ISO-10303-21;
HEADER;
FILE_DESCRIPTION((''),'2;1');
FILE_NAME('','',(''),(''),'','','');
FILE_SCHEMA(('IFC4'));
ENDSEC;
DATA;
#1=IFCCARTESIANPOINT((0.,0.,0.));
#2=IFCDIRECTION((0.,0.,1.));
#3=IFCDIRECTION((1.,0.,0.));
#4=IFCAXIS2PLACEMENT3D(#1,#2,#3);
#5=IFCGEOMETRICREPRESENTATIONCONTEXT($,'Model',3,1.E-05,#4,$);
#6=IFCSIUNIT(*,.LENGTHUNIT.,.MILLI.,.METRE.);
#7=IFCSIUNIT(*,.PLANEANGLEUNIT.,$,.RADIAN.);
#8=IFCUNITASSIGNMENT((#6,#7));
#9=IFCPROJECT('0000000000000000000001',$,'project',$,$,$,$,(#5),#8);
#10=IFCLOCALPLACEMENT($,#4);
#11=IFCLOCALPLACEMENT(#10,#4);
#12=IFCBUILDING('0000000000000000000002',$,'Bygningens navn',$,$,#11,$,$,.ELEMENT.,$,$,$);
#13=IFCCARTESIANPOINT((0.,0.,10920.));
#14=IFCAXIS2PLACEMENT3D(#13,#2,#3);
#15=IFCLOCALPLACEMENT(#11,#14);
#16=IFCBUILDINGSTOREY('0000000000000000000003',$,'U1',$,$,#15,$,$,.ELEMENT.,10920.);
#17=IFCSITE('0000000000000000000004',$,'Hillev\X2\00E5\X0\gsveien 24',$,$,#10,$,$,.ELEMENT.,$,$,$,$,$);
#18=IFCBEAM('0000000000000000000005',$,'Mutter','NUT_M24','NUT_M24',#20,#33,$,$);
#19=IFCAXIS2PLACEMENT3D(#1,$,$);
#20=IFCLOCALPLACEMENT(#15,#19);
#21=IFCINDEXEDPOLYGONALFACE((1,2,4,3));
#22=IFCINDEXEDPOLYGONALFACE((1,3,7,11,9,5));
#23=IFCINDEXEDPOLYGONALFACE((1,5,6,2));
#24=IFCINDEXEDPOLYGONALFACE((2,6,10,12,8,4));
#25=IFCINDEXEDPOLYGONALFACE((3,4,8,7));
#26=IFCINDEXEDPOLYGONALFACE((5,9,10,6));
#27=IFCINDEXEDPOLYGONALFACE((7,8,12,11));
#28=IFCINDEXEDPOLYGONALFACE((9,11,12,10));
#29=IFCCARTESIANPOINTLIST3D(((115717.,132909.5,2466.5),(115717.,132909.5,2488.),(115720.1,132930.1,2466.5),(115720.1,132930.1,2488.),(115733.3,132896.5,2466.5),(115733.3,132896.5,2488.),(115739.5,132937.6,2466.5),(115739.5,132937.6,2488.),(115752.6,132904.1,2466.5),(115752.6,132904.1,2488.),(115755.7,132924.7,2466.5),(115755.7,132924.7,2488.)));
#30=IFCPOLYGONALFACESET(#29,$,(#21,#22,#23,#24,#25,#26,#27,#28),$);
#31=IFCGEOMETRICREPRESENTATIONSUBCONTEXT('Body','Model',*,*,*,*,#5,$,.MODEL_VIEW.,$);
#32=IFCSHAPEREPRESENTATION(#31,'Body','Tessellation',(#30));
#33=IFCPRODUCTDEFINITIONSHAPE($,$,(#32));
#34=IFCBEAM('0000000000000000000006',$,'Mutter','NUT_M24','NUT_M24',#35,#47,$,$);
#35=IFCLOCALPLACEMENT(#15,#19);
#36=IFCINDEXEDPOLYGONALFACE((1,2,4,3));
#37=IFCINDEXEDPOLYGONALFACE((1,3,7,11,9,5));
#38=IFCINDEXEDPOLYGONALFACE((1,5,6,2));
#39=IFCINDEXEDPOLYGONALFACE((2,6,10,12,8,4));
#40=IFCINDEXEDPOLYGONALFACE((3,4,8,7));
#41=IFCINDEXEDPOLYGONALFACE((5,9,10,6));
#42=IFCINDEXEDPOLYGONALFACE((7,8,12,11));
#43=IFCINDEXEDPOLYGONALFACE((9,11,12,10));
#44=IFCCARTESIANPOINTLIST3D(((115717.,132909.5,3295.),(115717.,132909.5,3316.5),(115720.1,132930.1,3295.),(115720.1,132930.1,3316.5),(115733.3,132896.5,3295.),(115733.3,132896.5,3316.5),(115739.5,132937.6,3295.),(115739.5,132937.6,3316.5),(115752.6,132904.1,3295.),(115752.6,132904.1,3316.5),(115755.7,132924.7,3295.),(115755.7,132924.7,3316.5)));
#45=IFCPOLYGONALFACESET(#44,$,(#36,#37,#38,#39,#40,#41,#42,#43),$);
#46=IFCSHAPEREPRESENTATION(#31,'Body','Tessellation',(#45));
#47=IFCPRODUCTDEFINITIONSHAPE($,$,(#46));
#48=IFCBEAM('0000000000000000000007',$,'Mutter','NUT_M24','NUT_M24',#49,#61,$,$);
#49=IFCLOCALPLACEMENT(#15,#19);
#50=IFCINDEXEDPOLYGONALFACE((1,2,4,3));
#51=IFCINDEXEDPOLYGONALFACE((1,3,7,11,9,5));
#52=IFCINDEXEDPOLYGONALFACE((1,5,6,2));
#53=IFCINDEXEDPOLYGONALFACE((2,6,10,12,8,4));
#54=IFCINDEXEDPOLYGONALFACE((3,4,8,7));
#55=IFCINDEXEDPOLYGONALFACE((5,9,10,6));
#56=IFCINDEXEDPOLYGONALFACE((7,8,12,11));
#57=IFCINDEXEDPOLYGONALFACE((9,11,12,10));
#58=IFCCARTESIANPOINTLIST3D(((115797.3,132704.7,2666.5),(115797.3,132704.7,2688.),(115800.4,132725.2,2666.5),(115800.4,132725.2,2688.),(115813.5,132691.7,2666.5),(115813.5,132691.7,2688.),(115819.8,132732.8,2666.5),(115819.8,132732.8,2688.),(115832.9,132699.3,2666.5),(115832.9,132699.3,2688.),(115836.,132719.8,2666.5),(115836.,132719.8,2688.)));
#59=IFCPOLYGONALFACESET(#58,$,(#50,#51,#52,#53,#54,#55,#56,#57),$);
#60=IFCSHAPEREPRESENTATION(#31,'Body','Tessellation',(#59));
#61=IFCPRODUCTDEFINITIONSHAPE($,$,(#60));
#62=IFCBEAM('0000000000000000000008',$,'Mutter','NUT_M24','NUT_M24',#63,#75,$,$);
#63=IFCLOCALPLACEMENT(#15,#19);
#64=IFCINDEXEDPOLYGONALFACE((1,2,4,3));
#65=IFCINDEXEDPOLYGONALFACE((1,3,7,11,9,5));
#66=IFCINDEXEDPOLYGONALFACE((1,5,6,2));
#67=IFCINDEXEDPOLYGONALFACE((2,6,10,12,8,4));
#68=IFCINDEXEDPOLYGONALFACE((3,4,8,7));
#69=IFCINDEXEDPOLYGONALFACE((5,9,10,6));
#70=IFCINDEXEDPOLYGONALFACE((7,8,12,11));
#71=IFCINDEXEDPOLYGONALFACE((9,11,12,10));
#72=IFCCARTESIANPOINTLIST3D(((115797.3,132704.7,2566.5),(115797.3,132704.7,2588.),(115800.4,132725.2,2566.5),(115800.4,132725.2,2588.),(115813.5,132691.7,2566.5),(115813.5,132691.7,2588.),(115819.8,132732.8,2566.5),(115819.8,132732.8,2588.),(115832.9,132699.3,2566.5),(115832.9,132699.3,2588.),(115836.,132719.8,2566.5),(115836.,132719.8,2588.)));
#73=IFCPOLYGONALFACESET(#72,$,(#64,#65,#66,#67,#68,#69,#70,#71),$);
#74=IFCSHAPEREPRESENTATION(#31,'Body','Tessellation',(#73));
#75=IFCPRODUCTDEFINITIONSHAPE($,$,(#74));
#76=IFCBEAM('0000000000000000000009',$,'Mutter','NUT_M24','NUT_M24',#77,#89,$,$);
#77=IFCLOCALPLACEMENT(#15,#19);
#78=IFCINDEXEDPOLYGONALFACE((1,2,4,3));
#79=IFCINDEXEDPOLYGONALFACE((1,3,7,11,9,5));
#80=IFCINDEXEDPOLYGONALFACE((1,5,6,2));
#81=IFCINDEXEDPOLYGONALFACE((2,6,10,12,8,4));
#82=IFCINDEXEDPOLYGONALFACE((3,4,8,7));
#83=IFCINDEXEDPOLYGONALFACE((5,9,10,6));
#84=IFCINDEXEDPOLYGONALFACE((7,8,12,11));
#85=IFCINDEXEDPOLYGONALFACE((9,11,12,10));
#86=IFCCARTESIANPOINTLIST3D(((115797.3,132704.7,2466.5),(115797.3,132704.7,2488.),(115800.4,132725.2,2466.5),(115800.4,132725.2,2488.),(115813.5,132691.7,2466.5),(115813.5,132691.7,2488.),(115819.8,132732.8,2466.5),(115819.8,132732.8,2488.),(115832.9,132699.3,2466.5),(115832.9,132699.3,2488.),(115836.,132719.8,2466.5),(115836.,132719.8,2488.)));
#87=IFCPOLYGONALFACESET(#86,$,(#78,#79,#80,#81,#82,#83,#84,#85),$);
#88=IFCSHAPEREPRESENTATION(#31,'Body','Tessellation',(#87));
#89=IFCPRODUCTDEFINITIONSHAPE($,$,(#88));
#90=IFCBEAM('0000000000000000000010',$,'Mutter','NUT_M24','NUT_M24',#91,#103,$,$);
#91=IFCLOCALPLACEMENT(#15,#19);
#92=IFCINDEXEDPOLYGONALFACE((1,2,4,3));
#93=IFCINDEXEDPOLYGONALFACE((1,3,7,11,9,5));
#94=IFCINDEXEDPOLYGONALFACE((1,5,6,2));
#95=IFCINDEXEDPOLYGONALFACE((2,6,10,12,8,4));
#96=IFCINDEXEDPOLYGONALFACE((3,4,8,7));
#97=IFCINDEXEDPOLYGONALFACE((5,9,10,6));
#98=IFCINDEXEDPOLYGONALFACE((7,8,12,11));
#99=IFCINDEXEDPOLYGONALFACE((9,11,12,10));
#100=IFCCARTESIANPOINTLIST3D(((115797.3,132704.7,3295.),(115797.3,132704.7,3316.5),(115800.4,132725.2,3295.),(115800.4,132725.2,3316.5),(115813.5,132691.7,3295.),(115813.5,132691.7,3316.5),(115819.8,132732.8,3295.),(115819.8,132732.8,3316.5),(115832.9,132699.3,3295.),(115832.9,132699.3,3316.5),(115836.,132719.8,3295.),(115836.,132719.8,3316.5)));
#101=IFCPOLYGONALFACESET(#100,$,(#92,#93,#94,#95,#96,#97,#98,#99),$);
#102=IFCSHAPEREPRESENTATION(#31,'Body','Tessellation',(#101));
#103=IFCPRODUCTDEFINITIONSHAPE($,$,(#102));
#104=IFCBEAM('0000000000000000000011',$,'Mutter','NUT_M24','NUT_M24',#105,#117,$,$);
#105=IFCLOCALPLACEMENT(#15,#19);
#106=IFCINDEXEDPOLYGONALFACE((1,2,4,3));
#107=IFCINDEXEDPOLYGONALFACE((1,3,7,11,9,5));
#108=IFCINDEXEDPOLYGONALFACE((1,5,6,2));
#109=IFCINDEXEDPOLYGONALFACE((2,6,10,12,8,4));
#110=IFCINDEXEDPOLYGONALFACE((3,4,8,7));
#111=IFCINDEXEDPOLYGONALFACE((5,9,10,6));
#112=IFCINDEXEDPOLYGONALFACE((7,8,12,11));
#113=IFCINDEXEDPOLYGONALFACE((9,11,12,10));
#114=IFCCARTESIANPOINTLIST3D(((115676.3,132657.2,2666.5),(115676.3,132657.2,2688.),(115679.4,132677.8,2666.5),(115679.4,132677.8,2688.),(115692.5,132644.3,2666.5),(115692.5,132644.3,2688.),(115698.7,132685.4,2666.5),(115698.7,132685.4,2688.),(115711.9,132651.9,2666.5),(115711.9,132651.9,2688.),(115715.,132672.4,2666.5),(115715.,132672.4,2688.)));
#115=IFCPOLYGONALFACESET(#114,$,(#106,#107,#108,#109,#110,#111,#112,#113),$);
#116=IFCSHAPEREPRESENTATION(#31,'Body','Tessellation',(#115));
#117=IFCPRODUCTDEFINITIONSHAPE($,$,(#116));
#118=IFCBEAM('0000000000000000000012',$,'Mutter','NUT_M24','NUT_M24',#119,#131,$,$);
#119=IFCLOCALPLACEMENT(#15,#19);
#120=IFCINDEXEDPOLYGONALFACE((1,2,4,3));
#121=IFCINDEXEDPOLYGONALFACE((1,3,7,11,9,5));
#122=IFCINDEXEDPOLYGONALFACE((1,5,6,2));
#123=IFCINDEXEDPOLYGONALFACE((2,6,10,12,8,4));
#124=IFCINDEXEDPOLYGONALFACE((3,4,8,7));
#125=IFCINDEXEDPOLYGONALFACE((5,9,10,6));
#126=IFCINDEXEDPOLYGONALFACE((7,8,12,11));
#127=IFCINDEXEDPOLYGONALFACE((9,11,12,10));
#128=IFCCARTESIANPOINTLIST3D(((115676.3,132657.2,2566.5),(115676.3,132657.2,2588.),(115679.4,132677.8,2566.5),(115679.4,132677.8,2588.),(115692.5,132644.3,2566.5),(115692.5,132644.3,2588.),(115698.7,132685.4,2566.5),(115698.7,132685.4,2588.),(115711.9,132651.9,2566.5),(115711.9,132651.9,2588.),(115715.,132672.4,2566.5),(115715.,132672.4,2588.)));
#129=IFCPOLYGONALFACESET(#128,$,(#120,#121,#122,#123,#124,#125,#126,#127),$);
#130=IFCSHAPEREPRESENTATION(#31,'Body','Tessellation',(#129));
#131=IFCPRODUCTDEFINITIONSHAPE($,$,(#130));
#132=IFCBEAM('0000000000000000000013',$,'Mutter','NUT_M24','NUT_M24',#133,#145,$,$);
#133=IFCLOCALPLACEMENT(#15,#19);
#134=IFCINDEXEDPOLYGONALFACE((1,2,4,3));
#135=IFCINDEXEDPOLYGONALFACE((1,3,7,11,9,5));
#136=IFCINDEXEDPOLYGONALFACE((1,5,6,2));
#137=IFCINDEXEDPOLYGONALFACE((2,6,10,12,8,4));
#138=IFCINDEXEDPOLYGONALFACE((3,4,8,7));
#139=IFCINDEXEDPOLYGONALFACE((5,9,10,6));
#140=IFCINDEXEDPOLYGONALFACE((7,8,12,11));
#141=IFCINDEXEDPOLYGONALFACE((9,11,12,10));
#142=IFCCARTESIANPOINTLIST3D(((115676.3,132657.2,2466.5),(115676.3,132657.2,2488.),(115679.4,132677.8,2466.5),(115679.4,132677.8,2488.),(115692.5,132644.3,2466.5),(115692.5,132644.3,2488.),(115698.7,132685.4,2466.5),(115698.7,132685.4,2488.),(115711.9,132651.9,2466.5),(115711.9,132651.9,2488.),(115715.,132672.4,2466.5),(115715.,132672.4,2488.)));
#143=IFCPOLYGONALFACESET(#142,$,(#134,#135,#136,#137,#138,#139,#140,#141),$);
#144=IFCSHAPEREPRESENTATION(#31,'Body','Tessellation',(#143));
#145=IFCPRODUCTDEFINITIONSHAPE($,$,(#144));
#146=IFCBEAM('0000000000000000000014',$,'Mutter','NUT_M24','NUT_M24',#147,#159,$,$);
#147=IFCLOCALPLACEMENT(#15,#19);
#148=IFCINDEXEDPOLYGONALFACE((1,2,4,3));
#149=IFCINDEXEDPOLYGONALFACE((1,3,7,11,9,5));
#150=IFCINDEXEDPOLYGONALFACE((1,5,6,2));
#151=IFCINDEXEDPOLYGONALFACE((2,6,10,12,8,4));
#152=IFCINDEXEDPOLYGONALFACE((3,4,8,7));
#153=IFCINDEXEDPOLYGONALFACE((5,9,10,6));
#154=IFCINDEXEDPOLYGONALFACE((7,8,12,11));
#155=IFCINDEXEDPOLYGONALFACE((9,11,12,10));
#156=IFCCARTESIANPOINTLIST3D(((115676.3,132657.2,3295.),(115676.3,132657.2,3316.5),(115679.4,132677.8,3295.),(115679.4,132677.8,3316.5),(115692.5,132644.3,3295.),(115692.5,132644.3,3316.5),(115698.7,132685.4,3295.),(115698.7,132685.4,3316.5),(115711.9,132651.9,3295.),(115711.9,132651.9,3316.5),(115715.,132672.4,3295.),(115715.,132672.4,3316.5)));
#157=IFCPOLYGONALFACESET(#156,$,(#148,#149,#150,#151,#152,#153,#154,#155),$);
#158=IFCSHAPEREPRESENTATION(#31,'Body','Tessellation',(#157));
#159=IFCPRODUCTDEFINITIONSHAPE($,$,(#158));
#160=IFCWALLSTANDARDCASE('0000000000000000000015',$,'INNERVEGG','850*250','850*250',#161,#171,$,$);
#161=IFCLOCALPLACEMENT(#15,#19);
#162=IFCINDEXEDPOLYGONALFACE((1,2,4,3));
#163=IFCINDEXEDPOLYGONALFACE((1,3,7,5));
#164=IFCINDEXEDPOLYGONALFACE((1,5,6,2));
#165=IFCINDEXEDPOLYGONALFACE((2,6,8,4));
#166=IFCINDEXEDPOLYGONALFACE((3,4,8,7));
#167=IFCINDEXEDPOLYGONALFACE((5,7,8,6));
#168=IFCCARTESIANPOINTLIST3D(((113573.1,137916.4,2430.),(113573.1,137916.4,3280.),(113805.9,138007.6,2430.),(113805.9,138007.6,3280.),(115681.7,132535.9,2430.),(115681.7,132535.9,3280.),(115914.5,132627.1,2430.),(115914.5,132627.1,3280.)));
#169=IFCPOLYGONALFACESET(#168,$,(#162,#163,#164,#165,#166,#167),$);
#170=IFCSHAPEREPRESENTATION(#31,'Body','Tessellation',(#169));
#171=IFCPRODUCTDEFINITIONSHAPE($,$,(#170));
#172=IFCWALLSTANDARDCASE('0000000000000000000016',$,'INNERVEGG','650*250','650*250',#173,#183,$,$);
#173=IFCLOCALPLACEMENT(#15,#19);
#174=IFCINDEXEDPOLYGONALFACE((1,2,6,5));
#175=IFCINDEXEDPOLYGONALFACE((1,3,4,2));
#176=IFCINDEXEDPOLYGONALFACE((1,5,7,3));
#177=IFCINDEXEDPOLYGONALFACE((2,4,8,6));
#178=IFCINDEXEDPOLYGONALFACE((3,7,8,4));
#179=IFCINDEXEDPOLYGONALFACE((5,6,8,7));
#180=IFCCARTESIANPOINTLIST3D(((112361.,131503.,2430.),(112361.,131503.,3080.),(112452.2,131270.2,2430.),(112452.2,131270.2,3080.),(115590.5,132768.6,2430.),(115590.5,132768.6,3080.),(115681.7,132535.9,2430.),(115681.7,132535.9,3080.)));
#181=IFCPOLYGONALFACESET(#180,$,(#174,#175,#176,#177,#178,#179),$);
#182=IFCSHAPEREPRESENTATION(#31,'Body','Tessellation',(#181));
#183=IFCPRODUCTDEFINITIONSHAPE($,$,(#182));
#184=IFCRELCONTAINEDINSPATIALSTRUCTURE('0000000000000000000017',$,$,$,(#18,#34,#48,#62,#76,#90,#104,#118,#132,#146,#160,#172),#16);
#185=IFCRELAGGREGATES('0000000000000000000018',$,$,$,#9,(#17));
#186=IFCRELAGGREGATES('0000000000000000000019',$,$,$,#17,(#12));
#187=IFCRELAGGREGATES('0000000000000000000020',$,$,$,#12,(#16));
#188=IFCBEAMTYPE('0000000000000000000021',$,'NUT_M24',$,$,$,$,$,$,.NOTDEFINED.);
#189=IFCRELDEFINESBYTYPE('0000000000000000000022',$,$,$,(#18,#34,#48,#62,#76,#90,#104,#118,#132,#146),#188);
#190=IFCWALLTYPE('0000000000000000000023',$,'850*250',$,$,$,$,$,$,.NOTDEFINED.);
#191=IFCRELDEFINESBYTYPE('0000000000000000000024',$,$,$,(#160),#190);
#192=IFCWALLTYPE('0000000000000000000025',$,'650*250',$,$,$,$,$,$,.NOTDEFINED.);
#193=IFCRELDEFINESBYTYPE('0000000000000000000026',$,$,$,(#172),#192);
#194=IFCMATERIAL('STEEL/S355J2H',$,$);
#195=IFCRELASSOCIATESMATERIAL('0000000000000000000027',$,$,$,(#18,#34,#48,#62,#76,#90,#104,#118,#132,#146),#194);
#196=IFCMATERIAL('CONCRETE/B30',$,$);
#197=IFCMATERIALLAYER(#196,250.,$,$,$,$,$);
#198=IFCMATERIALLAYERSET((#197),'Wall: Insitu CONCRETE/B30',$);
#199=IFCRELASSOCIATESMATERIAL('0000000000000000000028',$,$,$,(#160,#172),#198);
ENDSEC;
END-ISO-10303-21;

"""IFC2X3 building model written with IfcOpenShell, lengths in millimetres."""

from ifc_helpers import new_model, si_unit, frame, frame_2d, origin_with_axes, place, context, subcontext, project, spatial, polyline, rectangle, outline, extrude, material, layer, layer_set, layer_usage, type_object, element, save


model = new_model("IFC2X3")

# Units and contexts
model_context = context("Model", 3, precision=1e-05, world=origin_with_axes())
body_context = subcontext(model_context, "Body", "Model", "MODEL_VIEW")
ifc_project = project(units=[si_unit("LENGTHUNIT", "METRE", prefix="MILLI"), si_unit("PLANEANGLEUNIT", "RADIAN")], contexts=[model_context])

# Site, building, storey
site_placement = place(None, origin_with_axes())
site = spatial("IfcSite", under=ifc_project, at=site_placement, Name="Hillevågsveien 24", CompositionType="ELEMENT")
building_placement = place(site_placement, origin_with_axes())
building = spatial("IfcBuilding", under=site, at=building_placement, Name="Bygningens navn", CompositionType="ELEMENT")
storey_placement = place(building_placement, frame((0.0, 0.0, 10920.0), z_axis=(0.0, 0.0, 1.0), x_axis=(1.0, 0.0, 0.0)))
storey = spatial("IfcBuildingStorey", under=building, at=storey_placement, Name="U1", CompositionType="ELEMENT", Elevation=10920.0)

# Shared definitions
ifc_material_1 = material(Name="CONCRETE/B30")

# Beams
ifc_material_2 = material(Name="STEEL/S355J2H")
beam_type_1 = type_object("IfcBeamType", Name="NUT_M24", PredefinedType="NOTDEFINED")
for number, where, z_axis, x_axis, name in (
    (1, (115736.4, 132917.1, 2488.0), (-0.364877, 0.931056, 0.0), (0.0, 0.0, -1.0), "Mutter"),
    (2, (115736.4, 132917.1, 3316.5), (-0.364877, 0.931056, 0.0), (0.0, 0.0, -1.0), "Mutter"),
    (3, (115816.6, 132712.3, 2688.0), (-0.364877, 0.931056, 0.0), (0.0, 0.0, -1.0), "Mutter"),
    (4, (115816.6, 132712.3, 2588.0), (-0.364877, 0.931056, 0.0), (0.0, 0.0, -1.0), "Mutter"),
    (5, (115816.6, 132712.3, 2488.0), (-0.364877, 0.931056, 0.0), (0.0, 0.0, -1.0), "Mutter"),
    (6, (115816.6, 132712.3, 3316.5), (-0.364877, 0.931056, 0.0), (0.0, 0.0, -1.0), "Mutter"),
    (7, (115695.6, 132664.8, 2688.0), (-0.364877, 0.931056, 0.0), (0.0, 0.0, -1.0), "Mutter"),
    (8, (115695.6, 132664.8, 2588.0), (-0.364877, 0.931056, 0.0), (0.0, 0.0, -1.0), "Mutter"),
    (9, (115695.6, 132664.8, 2488.0), (-0.364877, 0.931056, 0.0), (0.0, 0.0, -1.0), "Mutter"),
    (10, (115695.6, 132664.8, 3316.5), (-0.364877, 0.931056, 0.0), (0.0, 0.0, -1.0), "Mutter"),
):
    element("IfcBeam", number, at=place(storey_placement, frame(where, z_axis=z_axis, x_axis=x_axis)), inside=storey, type_object=beam_type_1, material=ifc_material_2, Name=name, Description="NUT_M24", ObjectType="NUT_M24", context=body_context, shape_type="SweptSolid", body=[
        extrude(outline(polyline([(-10.4, 18.0), (10.4, 18.0), (20.8, 0.0), (10.4, -18.0), (-10.4, -18.0), (-20.8, 0.0), (-10.4, 18.0)])), frame((21.5, 0.0, 0.0), z_axis=(-1.0, 0.0, 0.0), x_axis=(0.0, -1.0, 0.0)), (0.0, 0.0, 1.0), 21.5),
    ])

# Walls
ifc_layer = layer(ifc_material_1, 250.0)
ifc_layer_set = layer_set([ifc_layer], Name="Wall: Insitu CONCRETE/B30")
ifc_layer_usage_1 = layer_usage(ifc_layer_set, "AXIS2", "POSITIVE", -125.0)
wall_type_1 = type_object("IfcWallType", Name="850*250", PredefinedType="NOTDEFINED")
wall_1_placement = place(storey_placement, frame((115798.1, 132581.5, 2430.0), z_axis=(0.0, 0.0, 1.0), x_axis=(-0.364877, 0.931056, 0.0)))
element("IfcWallStandardCase", 11, at=wall_1_placement, inside=storey, type_object=wall_type_1, material=ifc_layer_usage_1, Name="INNERVEGG", Description="850*250", ObjectType="850*250", context=body_context, shape_type="SweptSolid", body=[
    extrude(rectangle(XDim=5779.0, YDim=250.0, at=frame_2d((0.0, 2889.5), x_axis=(0.0, -1.0))), frame((0.0, 0.0, 0.0), z_axis=(0.0, 0.0, 1.0), x_axis=(0.0, -1.0, 0.0)), (0.0, 0.0, 1.0), 850.0),
])
ifc_layer_usage_2 = layer_usage(ifc_layer_set, "AXIS2", "POSITIVE", -125.0)
wall_type_2 = type_object("IfcWallType", Name="650*250", PredefinedType="NOTDEFINED")
wall_2_placement = place(storey_placement, frame((112406.6, 131386.6, 2430.0), z_axis=(0.0, 0.0, 1.0), x_axis=(0.931056, 0.364875, 0.0)))
element("IfcWallStandardCase", 12, at=wall_2_placement, inside=storey, type_object=wall_type_2, material=ifc_layer_usage_2, Name="INNERVEGG", Description="650*250", ObjectType="650*250", context=body_context, shape_type="SweptSolid", body=[
    extrude(rectangle(XDim=3468.6, YDim=250.0, at=frame_2d((0.0, 1734.3), x_axis=(0.0, -1.0))), frame((0.0, 0.0, 0.0), z_axis=(0.0, 0.0, 1.0), x_axis=(0.0, -1.0, 0.0)), (0.0, 0.0, 1.0), 650.0),
])

save(model, "model.ifc")
